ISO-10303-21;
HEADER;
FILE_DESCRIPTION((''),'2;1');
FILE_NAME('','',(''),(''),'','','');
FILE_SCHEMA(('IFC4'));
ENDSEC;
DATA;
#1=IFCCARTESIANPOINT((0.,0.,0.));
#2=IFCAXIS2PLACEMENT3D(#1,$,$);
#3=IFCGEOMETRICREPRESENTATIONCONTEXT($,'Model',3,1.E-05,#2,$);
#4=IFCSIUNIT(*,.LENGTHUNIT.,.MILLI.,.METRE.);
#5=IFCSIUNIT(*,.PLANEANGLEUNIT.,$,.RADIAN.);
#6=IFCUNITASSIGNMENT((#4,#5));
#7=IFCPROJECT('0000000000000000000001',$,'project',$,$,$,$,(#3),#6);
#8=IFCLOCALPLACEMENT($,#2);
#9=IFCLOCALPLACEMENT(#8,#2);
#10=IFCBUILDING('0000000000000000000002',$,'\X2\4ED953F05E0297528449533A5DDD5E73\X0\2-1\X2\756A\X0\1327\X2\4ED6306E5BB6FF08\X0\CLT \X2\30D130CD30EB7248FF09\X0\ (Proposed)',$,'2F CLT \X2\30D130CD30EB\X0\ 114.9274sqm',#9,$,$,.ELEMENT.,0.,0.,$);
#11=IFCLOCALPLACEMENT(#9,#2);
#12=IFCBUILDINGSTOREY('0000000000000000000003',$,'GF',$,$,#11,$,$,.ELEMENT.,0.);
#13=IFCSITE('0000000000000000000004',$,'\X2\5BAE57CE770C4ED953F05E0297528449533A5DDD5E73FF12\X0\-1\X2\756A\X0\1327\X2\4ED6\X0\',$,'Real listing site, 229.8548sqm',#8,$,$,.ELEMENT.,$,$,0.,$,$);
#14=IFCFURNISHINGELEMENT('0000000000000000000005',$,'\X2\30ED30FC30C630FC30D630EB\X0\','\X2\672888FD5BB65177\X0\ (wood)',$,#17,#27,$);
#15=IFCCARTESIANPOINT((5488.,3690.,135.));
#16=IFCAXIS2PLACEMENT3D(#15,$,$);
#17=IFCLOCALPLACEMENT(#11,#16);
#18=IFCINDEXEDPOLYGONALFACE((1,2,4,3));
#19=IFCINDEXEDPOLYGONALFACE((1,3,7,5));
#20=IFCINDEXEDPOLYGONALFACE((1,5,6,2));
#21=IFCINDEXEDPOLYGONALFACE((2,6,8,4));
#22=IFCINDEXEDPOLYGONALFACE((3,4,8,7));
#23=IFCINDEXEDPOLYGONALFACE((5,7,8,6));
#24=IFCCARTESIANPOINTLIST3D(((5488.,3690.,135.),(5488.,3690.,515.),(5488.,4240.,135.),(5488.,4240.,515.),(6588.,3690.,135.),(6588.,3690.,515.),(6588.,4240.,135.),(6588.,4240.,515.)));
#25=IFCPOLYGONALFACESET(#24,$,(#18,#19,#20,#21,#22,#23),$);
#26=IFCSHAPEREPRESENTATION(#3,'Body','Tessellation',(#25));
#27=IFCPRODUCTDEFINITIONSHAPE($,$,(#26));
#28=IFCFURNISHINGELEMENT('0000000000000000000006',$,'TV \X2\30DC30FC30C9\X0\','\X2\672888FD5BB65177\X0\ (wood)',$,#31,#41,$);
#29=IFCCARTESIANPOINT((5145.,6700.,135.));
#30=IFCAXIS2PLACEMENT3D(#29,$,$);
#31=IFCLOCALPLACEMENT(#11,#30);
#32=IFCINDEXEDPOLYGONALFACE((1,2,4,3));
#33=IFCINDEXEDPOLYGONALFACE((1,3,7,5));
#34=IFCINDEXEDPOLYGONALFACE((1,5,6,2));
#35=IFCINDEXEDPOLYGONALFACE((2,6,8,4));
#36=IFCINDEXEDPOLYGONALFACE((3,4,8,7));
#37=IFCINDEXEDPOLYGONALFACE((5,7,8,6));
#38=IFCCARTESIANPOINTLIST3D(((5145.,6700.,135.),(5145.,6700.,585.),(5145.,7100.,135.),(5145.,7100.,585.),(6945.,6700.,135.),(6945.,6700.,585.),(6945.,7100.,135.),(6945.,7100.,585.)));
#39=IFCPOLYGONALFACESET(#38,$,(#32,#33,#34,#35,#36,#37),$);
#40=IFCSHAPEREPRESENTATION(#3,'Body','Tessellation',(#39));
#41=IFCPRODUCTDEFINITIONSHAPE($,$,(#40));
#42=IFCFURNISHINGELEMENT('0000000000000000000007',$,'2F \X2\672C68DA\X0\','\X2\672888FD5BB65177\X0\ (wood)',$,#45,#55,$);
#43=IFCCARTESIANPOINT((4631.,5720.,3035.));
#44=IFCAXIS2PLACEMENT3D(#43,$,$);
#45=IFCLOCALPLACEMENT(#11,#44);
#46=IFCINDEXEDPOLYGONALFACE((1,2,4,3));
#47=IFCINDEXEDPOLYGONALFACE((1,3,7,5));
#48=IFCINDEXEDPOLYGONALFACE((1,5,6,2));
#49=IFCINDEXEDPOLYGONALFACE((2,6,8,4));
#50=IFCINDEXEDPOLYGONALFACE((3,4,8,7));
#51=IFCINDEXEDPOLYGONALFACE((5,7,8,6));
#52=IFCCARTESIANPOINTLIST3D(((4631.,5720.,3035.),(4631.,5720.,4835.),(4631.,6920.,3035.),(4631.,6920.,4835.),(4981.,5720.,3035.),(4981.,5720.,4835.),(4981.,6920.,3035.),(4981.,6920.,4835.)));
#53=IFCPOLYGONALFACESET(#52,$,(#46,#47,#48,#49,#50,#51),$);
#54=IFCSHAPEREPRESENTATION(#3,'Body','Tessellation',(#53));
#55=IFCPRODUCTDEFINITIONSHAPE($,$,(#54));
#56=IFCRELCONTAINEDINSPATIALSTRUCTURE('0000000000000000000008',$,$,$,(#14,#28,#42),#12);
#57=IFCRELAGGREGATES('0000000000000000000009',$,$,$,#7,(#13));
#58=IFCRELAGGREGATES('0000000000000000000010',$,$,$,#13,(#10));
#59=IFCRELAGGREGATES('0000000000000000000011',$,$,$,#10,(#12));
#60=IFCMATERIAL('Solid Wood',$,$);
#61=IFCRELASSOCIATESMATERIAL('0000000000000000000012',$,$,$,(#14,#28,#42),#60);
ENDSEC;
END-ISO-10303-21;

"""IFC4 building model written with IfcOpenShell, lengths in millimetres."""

from ifc_helpers import new_model, si_unit, frame, frame_2d, origin, place, context, project, spatial, rectangle, extrude, material, element, save


model = new_model("IFC4")

# Units and contexts
model_context = context("Model", 3, precision=1e-05, world=origin())
ifc_project = project(units=[si_unit("LENGTHUNIT", "METRE", prefix="MILLI"), si_unit("PLANEANGLEUNIT", "RADIAN")], contexts=[model_context])

# Site, building, storey
site_placement = place(None, origin())
site = spatial("IfcSite", under=ifc_project, at=site_placement, Name="宮城県仙台市青葉区川平２-1番1327他", ObjectType="Real listing site, 229.8548sqm", CompositionType="ELEMENT", RefElevation=0.0)
building_placement = place(site_placement, origin())
building = spatial("IfcBuilding", under=site, at=building_placement, Name="仙台市青葉区川平2-1番1327他の家（CLT パネル版） (Proposed)", ObjectType="2F CLT パネル 114.9274sqm", CompositionType="ELEMENT", ElevationOfRefHeight=0.0, ElevationOfTerrain=0.0)
storey_placement = place(building_placement, origin())
storey = spatial("IfcBuildingStorey", under=building, at=storey_placement, Name="GF", CompositionType="ELEMENT", Elevation=0.0)

# Shared definitions
ifc_material_1 = material(Name="Solid Wood")

# Furnishing elements
furnishing_1_placement = place(storey_placement, frame((5488.0, 3690.0, 135.0)))
element("IfcFurnishingElement", 1, at=furnishing_1_placement, inside=storey, material=ifc_material_1, Name="ローテーブル", Description="木製家具 (wood)", context=model_context, shape_type="SweptSolid", body=[
    extrude(rectangle(XDim=1100.0, YDim=550.0, at=frame_2d((550.0, 275.0))), frame((5488.0, 3690.0, 135.0)), (0.0, 0.0, 1.0), 380.0),
])
furnishing_2_placement = place(storey_placement, frame((5145.0, 6700.0, 135.0)))
element("IfcFurnishingElement", 2, at=furnishing_2_placement, inside=storey, material=ifc_material_1, Name="TV ボード", Description="木製家具 (wood)", context=model_context, shape_type="SweptSolid", body=[
    extrude(rectangle(XDim=1800.0, YDim=400.0, at=frame_2d((900.0, 200.0))), frame((5145.0, 6700.0, 135.0)), (0.0, 0.0, 1.0), 450.0),
])
furnishing_3_placement = place(storey_placement, frame((4631.0, 5720.0, 3035.0)))
element("IfcFurnishingElement", 3, at=furnishing_3_placement, inside=storey, material=ifc_material_1, Name="2F 本棚", Description="木製家具 (wood)", context=model_context, shape_type="SweptSolid", body=[
    extrude(rectangle(XDim=350.0, YDim=1200.0, at=frame_2d((175.0, 600.0))), frame((4631.0, 5720.0, 3035.0)), (0.0, 0.0, 1.0), 1800.0),
])

save(model, "model.ifc")
